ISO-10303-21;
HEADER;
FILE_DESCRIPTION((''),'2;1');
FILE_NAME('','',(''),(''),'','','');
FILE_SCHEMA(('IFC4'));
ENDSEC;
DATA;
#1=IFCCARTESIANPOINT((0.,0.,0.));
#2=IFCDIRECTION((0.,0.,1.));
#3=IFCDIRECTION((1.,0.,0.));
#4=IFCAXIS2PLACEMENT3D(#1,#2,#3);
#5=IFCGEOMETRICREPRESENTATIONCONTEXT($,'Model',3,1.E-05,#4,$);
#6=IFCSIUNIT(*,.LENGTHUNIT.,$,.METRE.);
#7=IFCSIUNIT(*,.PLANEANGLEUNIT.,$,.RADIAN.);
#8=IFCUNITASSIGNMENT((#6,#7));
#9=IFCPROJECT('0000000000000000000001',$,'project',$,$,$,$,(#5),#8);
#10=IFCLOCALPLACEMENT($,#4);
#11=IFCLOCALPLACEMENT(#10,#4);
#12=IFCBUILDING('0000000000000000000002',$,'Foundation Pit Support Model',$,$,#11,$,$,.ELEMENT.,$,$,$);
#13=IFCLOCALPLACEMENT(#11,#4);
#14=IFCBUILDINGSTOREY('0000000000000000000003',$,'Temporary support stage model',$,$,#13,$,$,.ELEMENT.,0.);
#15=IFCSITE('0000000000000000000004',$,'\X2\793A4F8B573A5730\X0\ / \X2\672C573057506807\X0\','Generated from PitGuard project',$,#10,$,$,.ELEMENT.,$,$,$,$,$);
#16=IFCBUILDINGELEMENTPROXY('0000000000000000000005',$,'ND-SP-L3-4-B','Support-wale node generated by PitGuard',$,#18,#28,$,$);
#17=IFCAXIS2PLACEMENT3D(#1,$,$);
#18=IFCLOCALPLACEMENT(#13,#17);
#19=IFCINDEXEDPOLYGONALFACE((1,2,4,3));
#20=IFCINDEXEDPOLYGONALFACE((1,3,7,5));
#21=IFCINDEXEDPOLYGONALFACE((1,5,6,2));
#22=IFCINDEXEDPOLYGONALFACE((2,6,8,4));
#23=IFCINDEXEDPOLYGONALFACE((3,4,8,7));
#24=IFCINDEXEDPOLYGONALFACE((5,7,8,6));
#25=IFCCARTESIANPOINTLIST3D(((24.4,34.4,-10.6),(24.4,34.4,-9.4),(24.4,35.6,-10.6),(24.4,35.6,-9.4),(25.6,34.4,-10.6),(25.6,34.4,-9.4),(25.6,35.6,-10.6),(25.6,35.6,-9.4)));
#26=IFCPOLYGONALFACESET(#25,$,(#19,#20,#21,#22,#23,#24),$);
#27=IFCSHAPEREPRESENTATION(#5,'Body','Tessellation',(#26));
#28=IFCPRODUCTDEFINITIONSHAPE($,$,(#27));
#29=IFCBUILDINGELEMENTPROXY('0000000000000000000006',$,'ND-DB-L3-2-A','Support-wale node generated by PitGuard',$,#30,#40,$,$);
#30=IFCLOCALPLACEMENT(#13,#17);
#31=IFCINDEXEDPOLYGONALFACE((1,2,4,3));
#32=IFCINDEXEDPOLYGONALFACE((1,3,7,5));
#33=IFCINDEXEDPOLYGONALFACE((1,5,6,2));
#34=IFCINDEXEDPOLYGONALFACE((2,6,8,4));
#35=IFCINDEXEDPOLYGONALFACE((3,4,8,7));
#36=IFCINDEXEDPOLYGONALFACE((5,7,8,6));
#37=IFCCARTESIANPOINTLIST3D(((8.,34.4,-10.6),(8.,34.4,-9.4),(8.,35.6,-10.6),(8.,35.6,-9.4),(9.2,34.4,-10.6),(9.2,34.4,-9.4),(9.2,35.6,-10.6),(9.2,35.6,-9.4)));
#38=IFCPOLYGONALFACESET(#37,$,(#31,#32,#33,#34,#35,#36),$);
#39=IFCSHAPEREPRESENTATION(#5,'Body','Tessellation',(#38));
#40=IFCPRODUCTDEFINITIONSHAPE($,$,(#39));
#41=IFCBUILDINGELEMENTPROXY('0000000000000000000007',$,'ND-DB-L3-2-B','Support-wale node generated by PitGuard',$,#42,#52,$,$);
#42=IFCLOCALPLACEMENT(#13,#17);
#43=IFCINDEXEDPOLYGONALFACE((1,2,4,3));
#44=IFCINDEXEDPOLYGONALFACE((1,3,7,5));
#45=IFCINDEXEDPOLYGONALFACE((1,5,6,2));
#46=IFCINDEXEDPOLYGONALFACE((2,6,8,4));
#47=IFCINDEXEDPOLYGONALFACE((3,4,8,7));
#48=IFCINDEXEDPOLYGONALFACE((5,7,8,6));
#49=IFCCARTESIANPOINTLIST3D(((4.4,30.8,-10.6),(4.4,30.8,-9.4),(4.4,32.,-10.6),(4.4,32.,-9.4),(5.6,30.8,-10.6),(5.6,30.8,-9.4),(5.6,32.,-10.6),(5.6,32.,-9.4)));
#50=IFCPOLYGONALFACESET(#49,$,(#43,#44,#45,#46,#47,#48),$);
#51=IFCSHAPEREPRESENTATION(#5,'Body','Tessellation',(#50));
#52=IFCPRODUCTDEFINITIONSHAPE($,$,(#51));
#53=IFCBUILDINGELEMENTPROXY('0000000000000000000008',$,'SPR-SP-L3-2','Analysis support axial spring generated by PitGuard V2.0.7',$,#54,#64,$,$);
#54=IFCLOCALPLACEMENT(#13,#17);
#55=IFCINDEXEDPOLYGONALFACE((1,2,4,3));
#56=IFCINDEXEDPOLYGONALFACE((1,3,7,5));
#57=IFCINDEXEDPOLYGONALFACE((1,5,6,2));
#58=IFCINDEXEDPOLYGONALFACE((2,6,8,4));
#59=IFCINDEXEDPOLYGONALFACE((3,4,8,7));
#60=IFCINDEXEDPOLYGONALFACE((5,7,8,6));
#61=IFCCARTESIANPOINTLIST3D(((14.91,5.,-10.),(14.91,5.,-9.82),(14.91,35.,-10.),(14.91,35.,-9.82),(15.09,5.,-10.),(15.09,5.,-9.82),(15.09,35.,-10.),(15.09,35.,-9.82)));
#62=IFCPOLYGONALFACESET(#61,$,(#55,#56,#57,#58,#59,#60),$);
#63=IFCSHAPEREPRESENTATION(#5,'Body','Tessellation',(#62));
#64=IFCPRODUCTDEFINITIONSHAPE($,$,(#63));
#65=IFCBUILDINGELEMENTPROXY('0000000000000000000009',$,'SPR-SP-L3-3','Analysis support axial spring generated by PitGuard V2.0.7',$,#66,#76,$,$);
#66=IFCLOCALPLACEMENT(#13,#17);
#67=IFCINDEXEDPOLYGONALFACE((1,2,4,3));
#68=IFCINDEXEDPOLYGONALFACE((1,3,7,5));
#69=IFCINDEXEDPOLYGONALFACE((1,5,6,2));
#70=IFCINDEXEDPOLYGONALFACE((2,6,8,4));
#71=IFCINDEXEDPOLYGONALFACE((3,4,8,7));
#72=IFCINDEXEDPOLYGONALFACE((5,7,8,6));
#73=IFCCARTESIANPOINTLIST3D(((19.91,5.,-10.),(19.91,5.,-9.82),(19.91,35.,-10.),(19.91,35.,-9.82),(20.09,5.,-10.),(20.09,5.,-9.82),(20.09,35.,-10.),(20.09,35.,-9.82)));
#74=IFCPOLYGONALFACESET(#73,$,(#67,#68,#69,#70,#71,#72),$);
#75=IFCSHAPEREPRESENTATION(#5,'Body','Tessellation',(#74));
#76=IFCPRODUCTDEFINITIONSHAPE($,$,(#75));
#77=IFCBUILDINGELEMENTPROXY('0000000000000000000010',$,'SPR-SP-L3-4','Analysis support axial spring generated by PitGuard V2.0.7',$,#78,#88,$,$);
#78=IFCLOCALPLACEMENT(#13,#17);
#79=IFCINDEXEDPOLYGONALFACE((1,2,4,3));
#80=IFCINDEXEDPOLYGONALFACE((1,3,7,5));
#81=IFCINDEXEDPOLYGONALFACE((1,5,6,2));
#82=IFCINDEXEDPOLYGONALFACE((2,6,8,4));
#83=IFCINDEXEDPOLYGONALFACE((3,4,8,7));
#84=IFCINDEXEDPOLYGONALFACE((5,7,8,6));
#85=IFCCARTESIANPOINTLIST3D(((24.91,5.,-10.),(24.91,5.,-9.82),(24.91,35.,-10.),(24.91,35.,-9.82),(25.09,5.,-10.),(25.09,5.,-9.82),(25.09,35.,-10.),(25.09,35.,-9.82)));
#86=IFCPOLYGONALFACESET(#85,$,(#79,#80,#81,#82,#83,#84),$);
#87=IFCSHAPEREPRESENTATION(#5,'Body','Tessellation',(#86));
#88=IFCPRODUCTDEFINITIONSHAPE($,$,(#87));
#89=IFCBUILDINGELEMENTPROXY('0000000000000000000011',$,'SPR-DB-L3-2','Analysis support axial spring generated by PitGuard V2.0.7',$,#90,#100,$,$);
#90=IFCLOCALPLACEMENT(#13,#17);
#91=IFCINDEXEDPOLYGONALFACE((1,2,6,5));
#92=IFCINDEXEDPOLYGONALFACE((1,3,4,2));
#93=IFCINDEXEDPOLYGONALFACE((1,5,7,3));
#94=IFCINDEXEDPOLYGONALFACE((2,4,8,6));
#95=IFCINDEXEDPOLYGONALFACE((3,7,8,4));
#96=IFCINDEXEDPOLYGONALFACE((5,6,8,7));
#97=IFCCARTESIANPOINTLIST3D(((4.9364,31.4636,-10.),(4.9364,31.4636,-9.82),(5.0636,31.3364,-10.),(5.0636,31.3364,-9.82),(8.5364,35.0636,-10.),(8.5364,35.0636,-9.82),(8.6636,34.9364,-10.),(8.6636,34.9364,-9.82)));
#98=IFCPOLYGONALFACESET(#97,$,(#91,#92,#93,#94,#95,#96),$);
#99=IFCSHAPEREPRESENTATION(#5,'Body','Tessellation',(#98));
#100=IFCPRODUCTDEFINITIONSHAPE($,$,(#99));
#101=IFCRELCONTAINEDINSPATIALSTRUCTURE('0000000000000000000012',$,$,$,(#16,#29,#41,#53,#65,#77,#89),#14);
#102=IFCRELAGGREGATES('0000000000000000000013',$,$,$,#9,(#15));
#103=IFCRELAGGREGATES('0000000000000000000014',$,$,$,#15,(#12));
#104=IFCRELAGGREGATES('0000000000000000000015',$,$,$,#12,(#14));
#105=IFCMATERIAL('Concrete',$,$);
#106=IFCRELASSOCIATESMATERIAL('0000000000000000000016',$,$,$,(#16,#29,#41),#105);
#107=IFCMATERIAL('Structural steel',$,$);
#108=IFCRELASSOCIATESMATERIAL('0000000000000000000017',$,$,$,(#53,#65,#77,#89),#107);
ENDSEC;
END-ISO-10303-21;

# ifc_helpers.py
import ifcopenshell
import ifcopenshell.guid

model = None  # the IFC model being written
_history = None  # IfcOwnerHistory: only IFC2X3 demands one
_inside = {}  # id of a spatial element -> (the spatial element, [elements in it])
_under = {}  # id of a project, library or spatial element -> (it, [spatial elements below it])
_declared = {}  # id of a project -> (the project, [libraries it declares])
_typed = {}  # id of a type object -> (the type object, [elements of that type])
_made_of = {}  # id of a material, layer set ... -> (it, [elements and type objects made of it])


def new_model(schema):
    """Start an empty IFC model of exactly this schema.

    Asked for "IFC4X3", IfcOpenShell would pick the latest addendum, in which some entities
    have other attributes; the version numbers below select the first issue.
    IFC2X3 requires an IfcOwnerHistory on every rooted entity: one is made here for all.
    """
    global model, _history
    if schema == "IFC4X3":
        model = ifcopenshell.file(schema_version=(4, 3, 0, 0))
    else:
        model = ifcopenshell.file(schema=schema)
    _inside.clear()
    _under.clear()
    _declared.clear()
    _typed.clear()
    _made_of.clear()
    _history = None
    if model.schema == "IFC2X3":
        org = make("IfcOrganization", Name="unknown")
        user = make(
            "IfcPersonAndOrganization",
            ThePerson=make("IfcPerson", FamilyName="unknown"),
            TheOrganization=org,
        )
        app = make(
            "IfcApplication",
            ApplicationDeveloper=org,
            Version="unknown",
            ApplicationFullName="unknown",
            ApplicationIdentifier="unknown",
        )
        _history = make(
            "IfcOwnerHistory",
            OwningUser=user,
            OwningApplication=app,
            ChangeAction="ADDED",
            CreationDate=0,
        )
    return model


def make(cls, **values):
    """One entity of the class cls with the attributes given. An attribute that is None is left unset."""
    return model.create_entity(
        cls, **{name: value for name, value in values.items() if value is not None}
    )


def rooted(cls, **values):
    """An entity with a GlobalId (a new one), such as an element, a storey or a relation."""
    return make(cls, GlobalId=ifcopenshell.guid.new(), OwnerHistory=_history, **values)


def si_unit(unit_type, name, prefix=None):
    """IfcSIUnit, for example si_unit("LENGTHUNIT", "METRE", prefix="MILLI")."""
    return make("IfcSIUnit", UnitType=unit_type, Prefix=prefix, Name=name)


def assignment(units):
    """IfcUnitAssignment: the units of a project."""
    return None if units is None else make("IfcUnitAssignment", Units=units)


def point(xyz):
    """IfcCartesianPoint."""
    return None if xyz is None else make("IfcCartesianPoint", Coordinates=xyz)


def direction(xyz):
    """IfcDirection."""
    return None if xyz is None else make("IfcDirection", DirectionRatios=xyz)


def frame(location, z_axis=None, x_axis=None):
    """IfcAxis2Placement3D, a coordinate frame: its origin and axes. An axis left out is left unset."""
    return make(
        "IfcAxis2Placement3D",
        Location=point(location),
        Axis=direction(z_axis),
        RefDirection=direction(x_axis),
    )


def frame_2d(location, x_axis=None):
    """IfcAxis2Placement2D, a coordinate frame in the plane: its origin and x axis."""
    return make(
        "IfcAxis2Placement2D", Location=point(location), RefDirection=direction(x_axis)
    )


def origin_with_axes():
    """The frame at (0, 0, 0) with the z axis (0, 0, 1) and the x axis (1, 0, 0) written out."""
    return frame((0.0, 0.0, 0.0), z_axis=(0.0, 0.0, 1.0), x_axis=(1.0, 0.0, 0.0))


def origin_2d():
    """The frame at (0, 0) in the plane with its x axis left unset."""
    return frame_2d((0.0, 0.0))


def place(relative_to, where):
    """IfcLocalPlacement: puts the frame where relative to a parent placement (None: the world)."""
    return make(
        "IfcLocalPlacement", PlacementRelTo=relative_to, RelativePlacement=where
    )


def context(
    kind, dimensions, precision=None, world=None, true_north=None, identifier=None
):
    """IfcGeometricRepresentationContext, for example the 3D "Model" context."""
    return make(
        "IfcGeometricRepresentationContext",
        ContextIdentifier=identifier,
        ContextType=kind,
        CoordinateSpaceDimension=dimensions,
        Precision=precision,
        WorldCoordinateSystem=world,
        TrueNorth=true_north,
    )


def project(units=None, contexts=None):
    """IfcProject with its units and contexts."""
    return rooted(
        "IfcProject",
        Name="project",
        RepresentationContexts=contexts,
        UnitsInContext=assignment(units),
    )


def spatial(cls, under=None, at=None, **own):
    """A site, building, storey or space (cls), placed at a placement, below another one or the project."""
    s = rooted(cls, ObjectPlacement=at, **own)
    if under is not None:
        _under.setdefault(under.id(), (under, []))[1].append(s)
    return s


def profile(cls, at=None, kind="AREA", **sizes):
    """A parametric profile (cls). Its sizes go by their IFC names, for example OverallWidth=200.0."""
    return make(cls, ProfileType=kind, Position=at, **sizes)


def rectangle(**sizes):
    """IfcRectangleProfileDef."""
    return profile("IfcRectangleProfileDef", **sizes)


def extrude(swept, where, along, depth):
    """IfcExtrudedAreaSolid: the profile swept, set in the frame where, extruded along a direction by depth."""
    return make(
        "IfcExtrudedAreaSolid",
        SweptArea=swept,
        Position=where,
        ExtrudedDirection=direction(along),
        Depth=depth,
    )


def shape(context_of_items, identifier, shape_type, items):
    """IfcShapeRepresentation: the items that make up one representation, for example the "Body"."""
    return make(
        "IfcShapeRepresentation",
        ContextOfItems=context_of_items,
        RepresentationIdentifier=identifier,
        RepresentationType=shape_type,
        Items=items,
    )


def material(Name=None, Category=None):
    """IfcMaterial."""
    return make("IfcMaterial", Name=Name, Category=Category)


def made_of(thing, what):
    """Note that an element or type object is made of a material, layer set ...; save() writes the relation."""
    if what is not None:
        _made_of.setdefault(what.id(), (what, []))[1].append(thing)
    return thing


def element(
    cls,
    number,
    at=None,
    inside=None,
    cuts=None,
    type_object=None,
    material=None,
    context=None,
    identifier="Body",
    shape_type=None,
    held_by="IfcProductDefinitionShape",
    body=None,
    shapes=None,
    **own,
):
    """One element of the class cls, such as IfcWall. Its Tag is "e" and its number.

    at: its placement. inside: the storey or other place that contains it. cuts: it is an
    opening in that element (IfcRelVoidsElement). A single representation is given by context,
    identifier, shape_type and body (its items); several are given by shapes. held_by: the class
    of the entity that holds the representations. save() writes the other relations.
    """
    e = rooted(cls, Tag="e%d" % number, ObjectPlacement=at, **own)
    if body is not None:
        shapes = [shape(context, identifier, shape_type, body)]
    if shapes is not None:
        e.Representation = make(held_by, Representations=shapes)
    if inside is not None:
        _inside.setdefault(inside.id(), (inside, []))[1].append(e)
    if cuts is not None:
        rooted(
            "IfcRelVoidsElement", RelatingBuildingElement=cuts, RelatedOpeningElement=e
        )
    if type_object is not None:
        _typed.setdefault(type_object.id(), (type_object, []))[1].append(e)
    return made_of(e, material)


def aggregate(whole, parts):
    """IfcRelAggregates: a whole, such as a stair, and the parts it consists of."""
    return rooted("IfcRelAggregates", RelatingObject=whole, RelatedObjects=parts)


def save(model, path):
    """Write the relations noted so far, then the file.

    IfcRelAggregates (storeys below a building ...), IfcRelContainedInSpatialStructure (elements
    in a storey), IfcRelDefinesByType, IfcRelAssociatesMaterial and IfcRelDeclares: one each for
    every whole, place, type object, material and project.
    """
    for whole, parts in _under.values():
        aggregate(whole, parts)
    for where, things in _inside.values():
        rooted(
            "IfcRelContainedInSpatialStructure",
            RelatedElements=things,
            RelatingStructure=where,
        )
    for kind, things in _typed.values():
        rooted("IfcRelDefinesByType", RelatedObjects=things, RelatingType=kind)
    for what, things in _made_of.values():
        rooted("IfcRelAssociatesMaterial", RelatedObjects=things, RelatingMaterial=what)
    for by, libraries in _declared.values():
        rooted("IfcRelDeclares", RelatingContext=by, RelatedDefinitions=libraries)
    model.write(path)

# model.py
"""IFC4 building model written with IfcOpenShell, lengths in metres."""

from ifc_helpers import new_model, si_unit, frame, origin_with_axes, origin_2d, place, context, project, spatial, rectangle, extrude, material, element, save


model = new_model("IFC4")

# Units and contexts
model_context = context("Model", 3, precision=1e-05, world=origin_with_axes())
ifc_project = project(units=[si_unit("LENGTHUNIT", "METRE"), si_unit("PLANEANGLEUNIT", "RADIAN")], contexts=[model_context])

# Site, building, storey
site_placement = place(None, origin_with_axes())
site = spatial("IfcSite", under=ifc_project, at=site_placement, Name="示例场地 / 本地坐标", Description="Generated from PitGuard project", CompositionType="ELEMENT")
building_placement = place(site_placement, origin_with_axes())
building = spatial("IfcBuilding", under=site, at=building_placement, Name="Foundation Pit Support Model", CompositionType="ELEMENT")
storey_placement = place(building_placement, origin_with_axes())
storey = spatial("IfcBuildingStorey", under=building, at=storey_placement, Name="Temporary support stage model", CompositionType="ELEMENT", Elevation=0.0)

# Shared definitions
ifc_material_1 = material(Name="Structural steel")

# Shared definitions
ifc_material_2 = material(Name="Concrete")

# Building element proxies
for number, where, z_axis, x_axis, name in (
    (1, (25.0, 35.0, -10.6), (0.0, 0.0, 1.0), (1.0, 0.0, 0.0), "ND-SP-L3-4-B"),
    (2, (8.6, 35.0, -10.6), (0.0, 0.0, 1.0), (1.0, 0.0, 0.0), "ND-DB-L3-2-A"),
    (3, (5.0, 31.4, -10.6), (0.0, 0.0, 1.0), (1.0, 0.0, 0.0), "ND-DB-L3-2-B"),
):
    element("IfcBuildingElementProxy", number, at=place(storey_placement, frame(where, z_axis=z_axis, x_axis=x_axis)), inside=storey, material=ifc_material_2, Name=name, Description="Support-wale node generated by PitGuard", context=model_context, shape_type="SweptSolid", body=[
        extrude(rectangle(XDim=1.2, YDim=1.2, at=origin_2d()), origin_with_axes(), (0.0, 0.0, 1.0), 1.2),
    ])
for number, where, z_axis, x_axis, name in (
    (4, (15.0, 20.0, -10.0), (0.0, 0.0, 1.0), (0.0, 1.0, 0.0), "SPR-SP-L3-2"),
    (5, (20.0, 20.0, -10.0), (0.0, 0.0, 1.0), (0.0, 1.0, 0.0), "SPR-SP-L3-3"),
    (6, (25.0, 20.0, -10.0), (0.0, 0.0, 1.0), (0.0, 1.0, 0.0), "SPR-SP-L3-4"),
):
    element("IfcBuildingElementProxy", number, at=place(storey_placement, frame(where, z_axis=z_axis, x_axis=x_axis)), inside=storey, material=ifc_material_1, Name=name, Description="Analysis support axial spring generated by PitGuard V2.0.7", context=model_context, shape_type="SweptSolid", body=[
        extrude(rectangle(XDim=30.0, YDim=0.18, at=origin_2d()), origin_with_axes(), (0.0, 0.0, 1.0), 0.18),
    ])
proxy_placement = place(storey_placement, frame((6.8, 33.2, -10.0), z_axis=(0.0, 0.0, 1.0), x_axis=(-0.707107, -0.707107, 0.0)))
element("IfcBuildingElementProxy", 7, at=proxy_placement, inside=storey, material=ifc_material_1, Name="SPR-DB-L3-2", Description="Analysis support axial spring generated by PitGuard V2.0.7", context=model_context, shape_type="SweptSolid", body=[
    extrude(rectangle(XDim=5.0912, YDim=0.18, at=origin_2d()), origin_with_axes(), (0.0, 0.0, 1.0), 0.18),
])

save(model, "model.ifc")
